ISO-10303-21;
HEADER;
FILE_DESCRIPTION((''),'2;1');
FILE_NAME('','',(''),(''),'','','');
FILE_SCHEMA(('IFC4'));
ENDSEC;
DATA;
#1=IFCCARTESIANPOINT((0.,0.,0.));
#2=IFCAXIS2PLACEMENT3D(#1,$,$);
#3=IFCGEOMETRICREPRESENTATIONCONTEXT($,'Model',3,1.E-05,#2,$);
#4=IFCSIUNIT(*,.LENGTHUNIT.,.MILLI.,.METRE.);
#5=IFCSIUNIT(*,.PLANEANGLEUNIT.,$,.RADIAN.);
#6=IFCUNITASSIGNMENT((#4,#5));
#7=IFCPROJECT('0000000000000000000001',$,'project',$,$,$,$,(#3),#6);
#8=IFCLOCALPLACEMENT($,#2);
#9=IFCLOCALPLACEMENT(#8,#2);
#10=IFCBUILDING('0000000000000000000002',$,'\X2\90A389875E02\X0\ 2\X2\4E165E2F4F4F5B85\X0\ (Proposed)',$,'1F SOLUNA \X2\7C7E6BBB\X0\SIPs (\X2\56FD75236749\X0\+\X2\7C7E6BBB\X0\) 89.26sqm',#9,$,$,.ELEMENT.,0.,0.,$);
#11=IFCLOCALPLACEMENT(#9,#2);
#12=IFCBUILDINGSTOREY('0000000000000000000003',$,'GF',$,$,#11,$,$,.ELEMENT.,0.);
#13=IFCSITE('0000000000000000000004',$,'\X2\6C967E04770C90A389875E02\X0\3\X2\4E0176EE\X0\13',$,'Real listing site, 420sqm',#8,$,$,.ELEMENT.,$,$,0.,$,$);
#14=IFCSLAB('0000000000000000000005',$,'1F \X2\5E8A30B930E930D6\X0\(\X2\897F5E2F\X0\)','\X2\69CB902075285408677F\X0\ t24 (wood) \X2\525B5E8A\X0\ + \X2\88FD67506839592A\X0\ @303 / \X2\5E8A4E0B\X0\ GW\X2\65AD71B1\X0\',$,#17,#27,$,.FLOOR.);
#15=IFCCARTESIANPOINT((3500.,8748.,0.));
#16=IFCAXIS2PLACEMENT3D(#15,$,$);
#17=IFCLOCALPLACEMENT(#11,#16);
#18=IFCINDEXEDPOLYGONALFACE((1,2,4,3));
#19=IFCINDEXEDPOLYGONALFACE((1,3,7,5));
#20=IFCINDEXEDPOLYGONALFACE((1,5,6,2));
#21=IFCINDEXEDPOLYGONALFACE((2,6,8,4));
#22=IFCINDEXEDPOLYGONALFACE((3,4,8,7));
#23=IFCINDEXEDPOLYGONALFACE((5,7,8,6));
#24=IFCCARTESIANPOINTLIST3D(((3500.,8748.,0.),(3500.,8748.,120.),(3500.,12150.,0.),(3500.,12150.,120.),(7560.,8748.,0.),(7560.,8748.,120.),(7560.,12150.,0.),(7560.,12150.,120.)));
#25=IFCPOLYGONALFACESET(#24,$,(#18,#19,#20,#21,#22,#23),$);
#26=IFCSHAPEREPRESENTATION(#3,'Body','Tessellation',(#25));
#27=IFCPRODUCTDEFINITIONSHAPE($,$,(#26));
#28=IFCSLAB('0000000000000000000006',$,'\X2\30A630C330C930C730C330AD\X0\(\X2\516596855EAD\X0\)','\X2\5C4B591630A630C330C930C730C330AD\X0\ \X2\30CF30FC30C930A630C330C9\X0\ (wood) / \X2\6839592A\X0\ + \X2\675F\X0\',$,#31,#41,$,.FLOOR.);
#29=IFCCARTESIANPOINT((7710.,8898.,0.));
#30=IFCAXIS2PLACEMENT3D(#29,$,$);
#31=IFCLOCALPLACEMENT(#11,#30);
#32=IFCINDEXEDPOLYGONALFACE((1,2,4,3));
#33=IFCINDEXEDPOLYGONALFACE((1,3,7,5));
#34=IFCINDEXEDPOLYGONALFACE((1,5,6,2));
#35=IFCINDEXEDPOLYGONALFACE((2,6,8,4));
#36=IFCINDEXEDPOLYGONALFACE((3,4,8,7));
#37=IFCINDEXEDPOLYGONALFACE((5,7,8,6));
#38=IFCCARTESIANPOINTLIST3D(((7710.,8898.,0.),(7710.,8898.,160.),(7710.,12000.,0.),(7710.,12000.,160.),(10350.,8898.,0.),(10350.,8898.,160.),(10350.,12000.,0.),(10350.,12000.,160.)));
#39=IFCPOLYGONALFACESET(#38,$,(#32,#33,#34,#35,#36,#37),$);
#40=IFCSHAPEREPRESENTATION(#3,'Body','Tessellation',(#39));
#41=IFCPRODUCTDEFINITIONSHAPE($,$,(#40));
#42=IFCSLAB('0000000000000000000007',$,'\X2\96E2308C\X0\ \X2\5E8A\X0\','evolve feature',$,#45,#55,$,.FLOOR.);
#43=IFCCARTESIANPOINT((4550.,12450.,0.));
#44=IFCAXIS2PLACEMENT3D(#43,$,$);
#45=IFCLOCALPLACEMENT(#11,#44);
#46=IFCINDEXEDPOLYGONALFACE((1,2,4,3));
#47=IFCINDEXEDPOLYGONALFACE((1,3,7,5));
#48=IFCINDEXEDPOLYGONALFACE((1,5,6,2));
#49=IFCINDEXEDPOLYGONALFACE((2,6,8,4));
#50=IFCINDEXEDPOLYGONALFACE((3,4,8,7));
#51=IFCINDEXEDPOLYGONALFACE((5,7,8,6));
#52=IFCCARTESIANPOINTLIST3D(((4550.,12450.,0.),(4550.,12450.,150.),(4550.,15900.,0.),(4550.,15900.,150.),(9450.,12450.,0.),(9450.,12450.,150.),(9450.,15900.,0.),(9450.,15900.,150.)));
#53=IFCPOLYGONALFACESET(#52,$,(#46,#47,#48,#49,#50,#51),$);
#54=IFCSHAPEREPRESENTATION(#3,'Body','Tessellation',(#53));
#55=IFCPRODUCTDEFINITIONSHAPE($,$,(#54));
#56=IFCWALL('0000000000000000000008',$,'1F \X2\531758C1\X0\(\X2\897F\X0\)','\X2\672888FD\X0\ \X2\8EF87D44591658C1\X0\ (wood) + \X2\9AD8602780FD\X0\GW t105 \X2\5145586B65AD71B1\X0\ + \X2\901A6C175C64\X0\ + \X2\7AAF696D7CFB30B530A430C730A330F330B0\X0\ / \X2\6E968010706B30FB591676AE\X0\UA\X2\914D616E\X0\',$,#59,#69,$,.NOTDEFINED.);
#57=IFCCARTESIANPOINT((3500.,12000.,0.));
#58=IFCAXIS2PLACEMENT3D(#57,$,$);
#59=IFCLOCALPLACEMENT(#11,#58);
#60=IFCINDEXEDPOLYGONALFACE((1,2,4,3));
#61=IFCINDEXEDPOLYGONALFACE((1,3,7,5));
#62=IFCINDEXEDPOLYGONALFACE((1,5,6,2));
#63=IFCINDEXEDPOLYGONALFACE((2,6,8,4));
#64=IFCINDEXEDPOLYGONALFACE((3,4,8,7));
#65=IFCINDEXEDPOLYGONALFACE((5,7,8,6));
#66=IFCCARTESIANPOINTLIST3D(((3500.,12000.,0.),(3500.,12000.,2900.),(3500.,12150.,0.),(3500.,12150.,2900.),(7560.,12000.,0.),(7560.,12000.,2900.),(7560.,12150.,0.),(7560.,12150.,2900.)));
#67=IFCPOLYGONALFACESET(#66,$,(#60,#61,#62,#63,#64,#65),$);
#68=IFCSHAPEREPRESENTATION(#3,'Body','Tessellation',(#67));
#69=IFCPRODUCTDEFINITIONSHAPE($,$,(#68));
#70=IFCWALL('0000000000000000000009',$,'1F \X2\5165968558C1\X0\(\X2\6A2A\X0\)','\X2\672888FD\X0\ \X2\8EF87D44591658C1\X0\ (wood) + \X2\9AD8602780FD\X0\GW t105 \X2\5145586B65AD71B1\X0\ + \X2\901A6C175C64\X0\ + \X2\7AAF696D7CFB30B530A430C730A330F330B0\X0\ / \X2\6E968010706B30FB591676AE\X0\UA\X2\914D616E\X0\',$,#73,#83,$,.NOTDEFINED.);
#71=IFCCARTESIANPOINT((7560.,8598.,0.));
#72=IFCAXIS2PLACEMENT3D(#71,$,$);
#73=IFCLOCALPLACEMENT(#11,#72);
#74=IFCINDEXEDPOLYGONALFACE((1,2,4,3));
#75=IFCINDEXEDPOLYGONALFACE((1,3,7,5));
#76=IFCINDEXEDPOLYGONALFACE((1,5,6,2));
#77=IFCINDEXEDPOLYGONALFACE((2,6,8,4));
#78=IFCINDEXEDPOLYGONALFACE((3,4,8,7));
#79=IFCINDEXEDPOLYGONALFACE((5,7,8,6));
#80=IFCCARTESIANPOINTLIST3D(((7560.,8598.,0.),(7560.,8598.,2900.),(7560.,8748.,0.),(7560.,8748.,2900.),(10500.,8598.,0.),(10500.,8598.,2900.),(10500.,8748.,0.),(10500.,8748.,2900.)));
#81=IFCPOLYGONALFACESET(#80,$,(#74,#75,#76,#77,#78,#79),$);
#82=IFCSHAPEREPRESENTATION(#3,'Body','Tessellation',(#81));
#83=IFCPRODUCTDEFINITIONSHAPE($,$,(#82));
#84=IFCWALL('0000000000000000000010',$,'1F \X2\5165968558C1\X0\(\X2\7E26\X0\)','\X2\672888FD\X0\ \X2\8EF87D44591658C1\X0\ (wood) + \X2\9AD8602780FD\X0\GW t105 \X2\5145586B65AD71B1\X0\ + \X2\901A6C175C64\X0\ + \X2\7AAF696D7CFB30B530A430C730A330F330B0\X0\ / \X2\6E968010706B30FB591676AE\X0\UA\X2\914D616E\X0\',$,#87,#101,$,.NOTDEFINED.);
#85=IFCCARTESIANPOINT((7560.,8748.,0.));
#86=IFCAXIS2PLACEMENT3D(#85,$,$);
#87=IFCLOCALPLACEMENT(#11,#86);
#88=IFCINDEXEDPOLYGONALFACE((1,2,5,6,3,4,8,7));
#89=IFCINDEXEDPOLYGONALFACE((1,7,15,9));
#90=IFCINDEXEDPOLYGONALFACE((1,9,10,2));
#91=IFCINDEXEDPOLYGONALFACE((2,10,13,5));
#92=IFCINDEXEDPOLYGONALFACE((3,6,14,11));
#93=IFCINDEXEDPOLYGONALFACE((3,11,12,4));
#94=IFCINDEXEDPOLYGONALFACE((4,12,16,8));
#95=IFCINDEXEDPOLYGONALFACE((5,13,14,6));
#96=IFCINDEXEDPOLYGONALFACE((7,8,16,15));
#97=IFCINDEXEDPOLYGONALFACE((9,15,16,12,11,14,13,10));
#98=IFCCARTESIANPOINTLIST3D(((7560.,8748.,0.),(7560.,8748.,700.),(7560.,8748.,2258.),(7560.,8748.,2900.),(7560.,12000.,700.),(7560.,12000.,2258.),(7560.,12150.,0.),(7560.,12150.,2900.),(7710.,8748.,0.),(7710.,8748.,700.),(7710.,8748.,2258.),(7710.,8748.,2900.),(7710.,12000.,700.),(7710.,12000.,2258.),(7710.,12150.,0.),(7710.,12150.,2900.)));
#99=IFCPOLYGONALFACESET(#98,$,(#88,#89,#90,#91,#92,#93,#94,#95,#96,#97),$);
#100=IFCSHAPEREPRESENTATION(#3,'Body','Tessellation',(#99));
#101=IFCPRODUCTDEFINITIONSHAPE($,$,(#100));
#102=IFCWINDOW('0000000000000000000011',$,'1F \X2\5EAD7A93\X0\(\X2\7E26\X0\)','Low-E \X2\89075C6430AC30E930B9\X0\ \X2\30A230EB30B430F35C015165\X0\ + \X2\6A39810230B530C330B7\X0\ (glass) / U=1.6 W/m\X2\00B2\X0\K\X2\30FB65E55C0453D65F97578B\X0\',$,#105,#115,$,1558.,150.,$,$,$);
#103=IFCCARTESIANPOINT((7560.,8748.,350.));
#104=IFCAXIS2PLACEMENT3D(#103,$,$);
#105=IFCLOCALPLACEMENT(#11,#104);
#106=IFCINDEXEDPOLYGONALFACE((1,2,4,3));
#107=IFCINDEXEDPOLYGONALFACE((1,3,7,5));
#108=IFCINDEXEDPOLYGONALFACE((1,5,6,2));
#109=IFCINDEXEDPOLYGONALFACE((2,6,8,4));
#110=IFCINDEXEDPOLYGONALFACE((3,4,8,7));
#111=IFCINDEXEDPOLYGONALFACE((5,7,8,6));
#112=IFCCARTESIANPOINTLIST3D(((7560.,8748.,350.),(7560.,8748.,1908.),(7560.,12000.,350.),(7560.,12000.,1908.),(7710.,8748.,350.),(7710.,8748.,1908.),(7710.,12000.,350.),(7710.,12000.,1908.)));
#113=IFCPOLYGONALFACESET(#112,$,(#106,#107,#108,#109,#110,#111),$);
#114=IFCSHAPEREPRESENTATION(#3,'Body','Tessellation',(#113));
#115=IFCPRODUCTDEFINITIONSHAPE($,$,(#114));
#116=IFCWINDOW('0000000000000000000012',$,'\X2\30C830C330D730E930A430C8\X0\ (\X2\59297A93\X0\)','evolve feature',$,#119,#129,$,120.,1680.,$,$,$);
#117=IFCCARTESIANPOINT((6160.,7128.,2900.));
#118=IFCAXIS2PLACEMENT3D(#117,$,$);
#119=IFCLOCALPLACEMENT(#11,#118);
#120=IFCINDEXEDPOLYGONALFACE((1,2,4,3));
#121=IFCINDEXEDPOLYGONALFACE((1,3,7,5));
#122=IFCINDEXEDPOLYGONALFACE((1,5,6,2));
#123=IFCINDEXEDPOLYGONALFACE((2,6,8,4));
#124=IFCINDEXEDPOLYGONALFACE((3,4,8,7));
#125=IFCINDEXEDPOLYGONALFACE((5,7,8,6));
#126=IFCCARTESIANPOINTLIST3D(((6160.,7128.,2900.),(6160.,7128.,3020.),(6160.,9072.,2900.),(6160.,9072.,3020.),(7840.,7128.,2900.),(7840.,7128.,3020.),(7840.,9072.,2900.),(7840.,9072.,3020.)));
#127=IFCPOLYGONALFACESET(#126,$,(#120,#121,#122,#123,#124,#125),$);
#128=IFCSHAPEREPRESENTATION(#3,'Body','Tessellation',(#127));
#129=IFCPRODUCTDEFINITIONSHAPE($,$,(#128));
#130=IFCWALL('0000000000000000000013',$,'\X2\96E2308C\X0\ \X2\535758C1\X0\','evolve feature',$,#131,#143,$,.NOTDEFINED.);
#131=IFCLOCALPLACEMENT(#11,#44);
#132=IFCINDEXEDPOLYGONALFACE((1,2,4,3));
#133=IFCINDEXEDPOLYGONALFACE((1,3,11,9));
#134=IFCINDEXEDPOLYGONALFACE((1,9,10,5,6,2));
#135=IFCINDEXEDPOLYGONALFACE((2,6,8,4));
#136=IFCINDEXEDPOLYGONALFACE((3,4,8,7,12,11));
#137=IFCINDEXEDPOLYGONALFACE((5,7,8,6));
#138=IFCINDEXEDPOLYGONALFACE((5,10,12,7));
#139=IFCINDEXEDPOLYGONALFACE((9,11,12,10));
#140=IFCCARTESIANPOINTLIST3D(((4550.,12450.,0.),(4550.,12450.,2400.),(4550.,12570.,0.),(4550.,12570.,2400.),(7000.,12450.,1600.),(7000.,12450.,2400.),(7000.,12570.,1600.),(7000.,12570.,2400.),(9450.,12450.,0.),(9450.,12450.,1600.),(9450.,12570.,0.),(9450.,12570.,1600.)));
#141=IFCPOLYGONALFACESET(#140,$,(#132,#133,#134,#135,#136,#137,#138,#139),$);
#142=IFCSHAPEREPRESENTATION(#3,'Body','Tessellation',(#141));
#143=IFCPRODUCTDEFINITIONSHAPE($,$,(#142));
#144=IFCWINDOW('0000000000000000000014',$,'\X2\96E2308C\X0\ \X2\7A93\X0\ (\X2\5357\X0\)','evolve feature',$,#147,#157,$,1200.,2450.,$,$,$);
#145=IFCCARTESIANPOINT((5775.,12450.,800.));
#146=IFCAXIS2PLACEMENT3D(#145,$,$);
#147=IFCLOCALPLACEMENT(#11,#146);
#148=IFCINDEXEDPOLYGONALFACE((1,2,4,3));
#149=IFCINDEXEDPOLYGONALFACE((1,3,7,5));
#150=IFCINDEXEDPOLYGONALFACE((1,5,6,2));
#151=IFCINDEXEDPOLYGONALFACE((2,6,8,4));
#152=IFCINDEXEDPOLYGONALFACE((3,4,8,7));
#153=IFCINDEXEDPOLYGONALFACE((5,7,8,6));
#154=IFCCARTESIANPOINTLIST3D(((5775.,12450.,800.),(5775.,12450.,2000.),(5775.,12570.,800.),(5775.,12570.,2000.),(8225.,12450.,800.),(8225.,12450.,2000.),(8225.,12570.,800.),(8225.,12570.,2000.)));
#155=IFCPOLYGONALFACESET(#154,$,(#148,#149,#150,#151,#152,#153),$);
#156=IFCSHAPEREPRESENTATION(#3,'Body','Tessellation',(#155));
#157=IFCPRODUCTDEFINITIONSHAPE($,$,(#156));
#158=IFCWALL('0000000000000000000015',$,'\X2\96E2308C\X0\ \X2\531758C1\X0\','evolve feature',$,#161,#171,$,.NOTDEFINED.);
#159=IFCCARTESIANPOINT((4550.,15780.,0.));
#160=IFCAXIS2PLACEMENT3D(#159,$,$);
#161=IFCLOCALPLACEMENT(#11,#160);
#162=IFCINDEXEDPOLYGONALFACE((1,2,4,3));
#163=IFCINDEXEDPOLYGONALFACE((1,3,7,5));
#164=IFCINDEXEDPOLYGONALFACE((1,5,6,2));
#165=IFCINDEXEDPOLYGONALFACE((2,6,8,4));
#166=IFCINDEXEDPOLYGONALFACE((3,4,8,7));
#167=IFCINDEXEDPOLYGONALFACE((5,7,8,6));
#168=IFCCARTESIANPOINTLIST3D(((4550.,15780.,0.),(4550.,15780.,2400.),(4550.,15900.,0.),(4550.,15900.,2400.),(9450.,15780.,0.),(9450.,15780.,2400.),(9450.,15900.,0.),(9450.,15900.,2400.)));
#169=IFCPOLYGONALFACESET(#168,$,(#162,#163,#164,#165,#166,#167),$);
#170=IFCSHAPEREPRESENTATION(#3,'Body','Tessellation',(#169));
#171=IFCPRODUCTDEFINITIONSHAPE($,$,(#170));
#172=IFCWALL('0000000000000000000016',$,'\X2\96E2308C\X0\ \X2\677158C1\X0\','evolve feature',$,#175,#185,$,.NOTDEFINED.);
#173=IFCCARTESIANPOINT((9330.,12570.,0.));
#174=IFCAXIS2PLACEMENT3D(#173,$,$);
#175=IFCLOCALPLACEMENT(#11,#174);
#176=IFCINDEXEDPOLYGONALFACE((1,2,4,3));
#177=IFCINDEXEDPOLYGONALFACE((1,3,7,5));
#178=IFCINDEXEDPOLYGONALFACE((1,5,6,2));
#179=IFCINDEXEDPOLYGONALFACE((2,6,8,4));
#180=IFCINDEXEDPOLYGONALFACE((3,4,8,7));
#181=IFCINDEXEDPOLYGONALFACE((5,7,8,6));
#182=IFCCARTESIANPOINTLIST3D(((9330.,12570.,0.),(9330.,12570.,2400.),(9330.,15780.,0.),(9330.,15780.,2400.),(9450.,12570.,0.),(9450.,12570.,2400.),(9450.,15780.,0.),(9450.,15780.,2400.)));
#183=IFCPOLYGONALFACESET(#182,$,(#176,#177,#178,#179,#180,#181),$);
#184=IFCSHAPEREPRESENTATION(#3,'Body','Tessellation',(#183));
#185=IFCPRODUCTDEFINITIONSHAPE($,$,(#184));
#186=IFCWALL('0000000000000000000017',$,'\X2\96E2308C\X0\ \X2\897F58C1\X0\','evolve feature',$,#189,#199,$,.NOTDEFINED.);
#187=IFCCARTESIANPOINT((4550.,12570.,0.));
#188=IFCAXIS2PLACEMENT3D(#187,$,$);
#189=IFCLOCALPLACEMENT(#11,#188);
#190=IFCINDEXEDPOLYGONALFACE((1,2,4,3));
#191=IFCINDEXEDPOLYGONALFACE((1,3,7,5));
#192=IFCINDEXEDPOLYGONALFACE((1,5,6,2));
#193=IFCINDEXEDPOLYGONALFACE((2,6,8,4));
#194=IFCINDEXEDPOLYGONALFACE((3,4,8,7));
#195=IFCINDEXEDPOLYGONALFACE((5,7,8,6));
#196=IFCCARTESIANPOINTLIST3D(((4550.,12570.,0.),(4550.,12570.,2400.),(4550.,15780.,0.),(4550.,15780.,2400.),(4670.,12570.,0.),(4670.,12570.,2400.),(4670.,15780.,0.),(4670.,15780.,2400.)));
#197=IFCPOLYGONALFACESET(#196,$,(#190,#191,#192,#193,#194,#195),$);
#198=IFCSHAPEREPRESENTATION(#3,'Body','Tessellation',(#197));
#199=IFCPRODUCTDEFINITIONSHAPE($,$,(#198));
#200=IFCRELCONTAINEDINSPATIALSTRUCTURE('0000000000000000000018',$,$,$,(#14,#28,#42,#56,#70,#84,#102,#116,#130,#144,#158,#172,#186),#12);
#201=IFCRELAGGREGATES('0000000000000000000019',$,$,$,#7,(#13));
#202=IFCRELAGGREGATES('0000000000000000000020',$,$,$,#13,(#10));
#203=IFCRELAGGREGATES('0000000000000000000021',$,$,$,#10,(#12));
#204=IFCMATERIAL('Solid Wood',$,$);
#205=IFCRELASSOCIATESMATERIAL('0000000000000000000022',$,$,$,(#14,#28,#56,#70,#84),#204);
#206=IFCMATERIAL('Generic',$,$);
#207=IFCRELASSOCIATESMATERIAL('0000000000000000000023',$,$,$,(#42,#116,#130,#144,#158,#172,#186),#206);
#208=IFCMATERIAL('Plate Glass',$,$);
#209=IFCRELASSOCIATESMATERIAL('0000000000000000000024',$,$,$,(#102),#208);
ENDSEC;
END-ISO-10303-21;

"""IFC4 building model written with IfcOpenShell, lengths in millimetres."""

from ifc_helpers import new_model, si_unit, frame, frame_2d, origin, place, context, project, spatial, rectangle, extrude, material, element, fill, save


model = new_model("IFC4")

# Units and contexts
model_context = context("Model", 3, precision=1e-05, world=origin())
ifc_project = project(units=[si_unit("LENGTHUNIT", "METRE", prefix="MILLI"), si_unit("PLANEANGLEUNIT", "RADIAN")], contexts=[model_context])

# Site, building, storey
site_placement = place(None, origin())
site = spatial("IfcSite", under=ifc_project, at=site_placement, Name="沖縄県那覇市3丁目13", ObjectType="Real listing site, 420sqm", CompositionType="ELEMENT", RefElevation=0.0)
building_placement = place(site_placement, origin())
building = spatial("IfcBuilding", under=site, at=building_placement, Name="那覇市 2世帯住宅 (Proposed)", ObjectType="1F SOLUNA 籾殻SIPs (国産杉+籾殻) 89.26sqm", CompositionType="ELEMENT", ElevationOfRefHeight=0.0, ElevationOfTerrain=0.0)
storey_placement = place(building_placement, origin())
storey = spatial("IfcBuildingStorey", under=building, at=storey_placement, Name="GF", CompositionType="ELEMENT", Elevation=0.0)

# Slabs
ifc_material_1 = material(Name="Solid Wood")
slab_1_placement = place(storey_placement, frame((3500.0, 8748.0, 0.0)))
element("IfcSlab", 1, at=slab_1_placement, inside=storey, material=ifc_material_1, Name="1F 床スラブ(西帯)", Description="構造用合板 t24 (wood) 剛床 + 製材根太 @303 / 床下 GW断熱", PredefinedType="FLOOR", context=model_context, shape_type="SweptSolid", body=[
    extrude(rectangle(XDim=4060.0, YDim=3402.0, at=frame_2d((2030.0, 1701.0))), frame((3500.0, 8748.0, 0.0)), (0.0, 0.0, 1.0), 120.0),
])
slab_2_placement = place(storey_placement, frame((7710.0, 8898.0, 0.0)))
element("IfcSlab", 2, at=slab_2_placement, inside=storey, material=ifc_material_1, Name="ウッドデッキ(入隅庭)", Description="屋外ウッドデッキ ハードウッド (wood) / 根太 + 束", PredefinedType="FLOOR", context=model_context, shape_type="SweptSolid", body=[
    extrude(rectangle(XDim=2640.0, YDim=3102.0, at=frame_2d((1320.0, 1551.0))), frame((7710.0, 8898.0, 0.0)), (0.0, 0.0, 1.0), 160.0),
])
ifc_material_2 = material(Name="Generic")
slab_3_placement = place(storey_placement, frame((4550.0, 12450.0, 0.0)))
element("IfcSlab", 3, at=slab_3_placement, inside=storey, material=ifc_material_2, Name="離れ 床", Description="evolve feature", PredefinedType="FLOOR", context=model_context, shape_type="SweptSolid", body=[
    extrude(rectangle(XDim=4900.0, YDim=3450.0, at=frame_2d((2450.0, 1725.0))), frame((4550.0, 12450.0, 0.0)), (0.0, 0.0, 1.0), 150.0),
])

# Walls
wall_1_placement = place(storey_placement, frame((3500.0, 12000.0, 0.0)))
element("IfcWall", 4, at=wall_1_placement, inside=storey, material=ifc_material_1, Name="1F 北壁(西)", Description="木製 軸組外壁 (wood) + 高性能GW t105 充填断熱 + 通気層 + 窯業系サイディング / 準耐火・外皮UA配慮", PredefinedType="NOTDEFINED", context=model_context, shape_type="SweptSolid", body=[
    extrude(rectangle(XDim=4060.0, YDim=150.0, at=frame_2d((2030.0, 75.0))), frame((3500.0, 12000.0, 0.0)), (0.0, 0.0, 1.0), 2900.0),
])
wall_2_placement = place(storey_placement, frame((7560.0, 8598.0, 0.0)))
element("IfcWall", 5, at=wall_2_placement, inside=storey, material=ifc_material_1, Name="1F 入隅壁(横)", Description="木製 軸組外壁 (wood) + 高性能GW t105 充填断熱 + 通気層 + 窯業系サイディング / 準耐火・外皮UA配慮", PredefinedType="NOTDEFINED", context=model_context, shape_type="SweptSolid", body=[
    extrude(rectangle(XDim=2940.0, YDim=150.0, at=frame_2d((1470.0, 75.0))), frame((7560.0, 8598.0, 0.0)), (0.0, 0.0, 1.0), 2900.0),
])

# Wall, opening, window
wall_3_placement = place(storey_placement, frame((7560.0, 8748.0, 0.0)))
wall_3 = element("IfcWall", 6, at=wall_3_placement, inside=storey, material=ifc_material_1, Name="1F 入隅壁(縦)", Description="木製 軸組外壁 (wood) + 高性能GW t105 充填断熱 + 通気層 + 窯業系サイディング / 準耐火・外皮UA配慮", PredefinedType="NOTDEFINED", context=model_context, shape_type="SweptSolid", body=[
    extrude(rectangle(XDim=150.0, YDim=3402.0, at=frame_2d((75.0, 1701.0))), frame((7560.0, 8748.0, 0.0)), (0.0, 0.0, 1.0), 2900.0),
])
opening_1_placement = place(storey_placement, frame((7560.0, 8748.0, 350.0)))
opening_1 = element("IfcOpeningElement", 7, at=opening_1_placement, cuts=wall_3, PredefinedType="NOTDEFINED", context=model_context, shape_type="SweptSolid", body=[
    extrude(rectangle(XDim=150.0, YDim=3252.0, at=frame_2d((75.0, 1626.0))), frame((7560.0, 8748.0, 350.0)), (0.0, 0.0, 1.0), 1558.0),
])
ifc_material_3 = material(Name="Plate Glass")
window_1_placement = place(storey_placement, frame((7560.0, 8748.0, 350.0)))
window_1 = element("IfcWindow", 8, at=window_1_placement, inside=storey, material=ifc_material_3, Name="1F 庭窓(縦)", Description="Low-E 複層ガラス アルゴン封入 + 樹脂サッシ (glass) / U=1.6 W/m²K・日射取得型", OverallHeight=1558.0, OverallWidth=150.0, context=model_context, shape_type="SweptSolid", body=[
    extrude(rectangle(XDim=150.0, YDim=3252.0, at=frame_2d((75.0, 1626.0))), frame((7560.0, 8748.0, 350.0)), (0.0, 0.0, 1.0), 1558.0),
])
fill(opening_1, window_1)

# Window
window_2_placement = place(storey_placement, frame((6160.0, 7128.0, 2900.0)))
element("IfcWindow", 9, at=window_2_placement, inside=storey, material=ifc_material_2, Name="トップライト (天窓)", Description="evolve feature", OverallHeight=120.0, OverallWidth=1680.0, context=model_context, shape_type="SweptSolid", body=[
    extrude(rectangle(XDim=1680.0, YDim=1944.0, at=frame_2d((840.0, 972.0))), frame((6160.0, 7128.0, 2900.0)), (0.0, 0.0, 1.0), 120.0),
])

# Wall, opening, window
wall_4_placement = place(storey_placement, frame((4550.0, 12450.0, 0.0)))
wall_4 = element("IfcWall", 10, at=wall_4_placement, inside=storey, material=ifc_material_2, Name="離れ 南壁", Description="evolve feature", PredefinedType="NOTDEFINED", context=model_context, shape_type="SweptSolid", body=[
    extrude(rectangle(XDim=4900.0, YDim=120.0, at=frame_2d((2450.0, 60.0))), frame((4550.0, 12450.0, 0.0)), (0.0, 0.0, 1.0), 2400.0),
])
opening_2_placement = place(storey_placement, frame((5775.0, 12450.0, 800.0)))
opening_2 = element("IfcOpeningElement", 11, at=opening_2_placement, cuts=wall_4, PredefinedType="NOTDEFINED", context=model_context, shape_type="SweptSolid", body=[
    extrude(rectangle(XDim=2450.0, YDim=120.0, at=frame_2d((1225.0, 60.0))), frame((5775.0, 12450.0, 800.0)), (0.0, 0.0, 1.0), 1200.0),
])
window_3_placement = place(storey_placement, frame((5775.0, 12450.0, 800.0)))
window_3 = element("IfcWindow", 12, at=window_3_placement, inside=storey, material=ifc_material_2, Name="離れ 窓 (南)", Description="evolve feature", OverallHeight=1200.0, OverallWidth=2450.0, context=model_context, shape_type="SweptSolid", body=[
    extrude(rectangle(XDim=2450.0, YDim=120.0, at=frame_2d((1225.0, 60.0))), frame((5775.0, 12450.0, 800.0)), (0.0, 0.0, 1.0), 1200.0),
])
fill(opening_2, window_3)

# Walls
wall_5_placement = place(storey_placement, frame((4550.0, 15780.0, 0.0)))
element("IfcWall", 13, at=wall_5_placement, inside=storey, material=ifc_material_2, Name="離れ 北壁", Description="evolve feature", PredefinedType="NOTDEFINED", context=model_context, shape_type="SweptSolid", body=[
    extrude(rectangle(XDim=4900.0, YDim=120.0, at=frame_2d((2450.0, 60.0))), frame((4550.0, 15780.0, 0.0)), (0.0, 0.0, 1.0), 2400.0),
])
wall_6_placement = place(storey_placement, frame((9330.0, 12570.0, 0.0)))
element("IfcWall", 14, at=wall_6_placement, inside=storey, material=ifc_material_2, Name="離れ 東壁", Description="evolve feature", PredefinedType="NOTDEFINED", context=model_context, shape_type="SweptSolid", body=[
    extrude(rectangle(XDim=120.0, YDim=3210.0, at=frame_2d((60.0, 1605.0))), frame((9330.0, 12570.0, 0.0)), (0.0, 0.0, 1.0), 2400.0),
])
wall_7_placement = place(storey_placement, frame((4550.0, 12570.0, 0.0)))
element("IfcWall", 15, at=wall_7_placement, inside=storey, material=ifc_material_2, Name="離れ 西壁", Description="evolve feature", PredefinedType="NOTDEFINED", context=model_context, shape_type="SweptSolid", body=[
    extrude(rectangle(XDim=120.0, YDim=3210.0, at=frame_2d((60.0, 1605.0))), frame((4550.0, 12570.0, 0.0)), (0.0, 0.0, 1.0), 2400.0),
])

save(model, "model.ifc")
